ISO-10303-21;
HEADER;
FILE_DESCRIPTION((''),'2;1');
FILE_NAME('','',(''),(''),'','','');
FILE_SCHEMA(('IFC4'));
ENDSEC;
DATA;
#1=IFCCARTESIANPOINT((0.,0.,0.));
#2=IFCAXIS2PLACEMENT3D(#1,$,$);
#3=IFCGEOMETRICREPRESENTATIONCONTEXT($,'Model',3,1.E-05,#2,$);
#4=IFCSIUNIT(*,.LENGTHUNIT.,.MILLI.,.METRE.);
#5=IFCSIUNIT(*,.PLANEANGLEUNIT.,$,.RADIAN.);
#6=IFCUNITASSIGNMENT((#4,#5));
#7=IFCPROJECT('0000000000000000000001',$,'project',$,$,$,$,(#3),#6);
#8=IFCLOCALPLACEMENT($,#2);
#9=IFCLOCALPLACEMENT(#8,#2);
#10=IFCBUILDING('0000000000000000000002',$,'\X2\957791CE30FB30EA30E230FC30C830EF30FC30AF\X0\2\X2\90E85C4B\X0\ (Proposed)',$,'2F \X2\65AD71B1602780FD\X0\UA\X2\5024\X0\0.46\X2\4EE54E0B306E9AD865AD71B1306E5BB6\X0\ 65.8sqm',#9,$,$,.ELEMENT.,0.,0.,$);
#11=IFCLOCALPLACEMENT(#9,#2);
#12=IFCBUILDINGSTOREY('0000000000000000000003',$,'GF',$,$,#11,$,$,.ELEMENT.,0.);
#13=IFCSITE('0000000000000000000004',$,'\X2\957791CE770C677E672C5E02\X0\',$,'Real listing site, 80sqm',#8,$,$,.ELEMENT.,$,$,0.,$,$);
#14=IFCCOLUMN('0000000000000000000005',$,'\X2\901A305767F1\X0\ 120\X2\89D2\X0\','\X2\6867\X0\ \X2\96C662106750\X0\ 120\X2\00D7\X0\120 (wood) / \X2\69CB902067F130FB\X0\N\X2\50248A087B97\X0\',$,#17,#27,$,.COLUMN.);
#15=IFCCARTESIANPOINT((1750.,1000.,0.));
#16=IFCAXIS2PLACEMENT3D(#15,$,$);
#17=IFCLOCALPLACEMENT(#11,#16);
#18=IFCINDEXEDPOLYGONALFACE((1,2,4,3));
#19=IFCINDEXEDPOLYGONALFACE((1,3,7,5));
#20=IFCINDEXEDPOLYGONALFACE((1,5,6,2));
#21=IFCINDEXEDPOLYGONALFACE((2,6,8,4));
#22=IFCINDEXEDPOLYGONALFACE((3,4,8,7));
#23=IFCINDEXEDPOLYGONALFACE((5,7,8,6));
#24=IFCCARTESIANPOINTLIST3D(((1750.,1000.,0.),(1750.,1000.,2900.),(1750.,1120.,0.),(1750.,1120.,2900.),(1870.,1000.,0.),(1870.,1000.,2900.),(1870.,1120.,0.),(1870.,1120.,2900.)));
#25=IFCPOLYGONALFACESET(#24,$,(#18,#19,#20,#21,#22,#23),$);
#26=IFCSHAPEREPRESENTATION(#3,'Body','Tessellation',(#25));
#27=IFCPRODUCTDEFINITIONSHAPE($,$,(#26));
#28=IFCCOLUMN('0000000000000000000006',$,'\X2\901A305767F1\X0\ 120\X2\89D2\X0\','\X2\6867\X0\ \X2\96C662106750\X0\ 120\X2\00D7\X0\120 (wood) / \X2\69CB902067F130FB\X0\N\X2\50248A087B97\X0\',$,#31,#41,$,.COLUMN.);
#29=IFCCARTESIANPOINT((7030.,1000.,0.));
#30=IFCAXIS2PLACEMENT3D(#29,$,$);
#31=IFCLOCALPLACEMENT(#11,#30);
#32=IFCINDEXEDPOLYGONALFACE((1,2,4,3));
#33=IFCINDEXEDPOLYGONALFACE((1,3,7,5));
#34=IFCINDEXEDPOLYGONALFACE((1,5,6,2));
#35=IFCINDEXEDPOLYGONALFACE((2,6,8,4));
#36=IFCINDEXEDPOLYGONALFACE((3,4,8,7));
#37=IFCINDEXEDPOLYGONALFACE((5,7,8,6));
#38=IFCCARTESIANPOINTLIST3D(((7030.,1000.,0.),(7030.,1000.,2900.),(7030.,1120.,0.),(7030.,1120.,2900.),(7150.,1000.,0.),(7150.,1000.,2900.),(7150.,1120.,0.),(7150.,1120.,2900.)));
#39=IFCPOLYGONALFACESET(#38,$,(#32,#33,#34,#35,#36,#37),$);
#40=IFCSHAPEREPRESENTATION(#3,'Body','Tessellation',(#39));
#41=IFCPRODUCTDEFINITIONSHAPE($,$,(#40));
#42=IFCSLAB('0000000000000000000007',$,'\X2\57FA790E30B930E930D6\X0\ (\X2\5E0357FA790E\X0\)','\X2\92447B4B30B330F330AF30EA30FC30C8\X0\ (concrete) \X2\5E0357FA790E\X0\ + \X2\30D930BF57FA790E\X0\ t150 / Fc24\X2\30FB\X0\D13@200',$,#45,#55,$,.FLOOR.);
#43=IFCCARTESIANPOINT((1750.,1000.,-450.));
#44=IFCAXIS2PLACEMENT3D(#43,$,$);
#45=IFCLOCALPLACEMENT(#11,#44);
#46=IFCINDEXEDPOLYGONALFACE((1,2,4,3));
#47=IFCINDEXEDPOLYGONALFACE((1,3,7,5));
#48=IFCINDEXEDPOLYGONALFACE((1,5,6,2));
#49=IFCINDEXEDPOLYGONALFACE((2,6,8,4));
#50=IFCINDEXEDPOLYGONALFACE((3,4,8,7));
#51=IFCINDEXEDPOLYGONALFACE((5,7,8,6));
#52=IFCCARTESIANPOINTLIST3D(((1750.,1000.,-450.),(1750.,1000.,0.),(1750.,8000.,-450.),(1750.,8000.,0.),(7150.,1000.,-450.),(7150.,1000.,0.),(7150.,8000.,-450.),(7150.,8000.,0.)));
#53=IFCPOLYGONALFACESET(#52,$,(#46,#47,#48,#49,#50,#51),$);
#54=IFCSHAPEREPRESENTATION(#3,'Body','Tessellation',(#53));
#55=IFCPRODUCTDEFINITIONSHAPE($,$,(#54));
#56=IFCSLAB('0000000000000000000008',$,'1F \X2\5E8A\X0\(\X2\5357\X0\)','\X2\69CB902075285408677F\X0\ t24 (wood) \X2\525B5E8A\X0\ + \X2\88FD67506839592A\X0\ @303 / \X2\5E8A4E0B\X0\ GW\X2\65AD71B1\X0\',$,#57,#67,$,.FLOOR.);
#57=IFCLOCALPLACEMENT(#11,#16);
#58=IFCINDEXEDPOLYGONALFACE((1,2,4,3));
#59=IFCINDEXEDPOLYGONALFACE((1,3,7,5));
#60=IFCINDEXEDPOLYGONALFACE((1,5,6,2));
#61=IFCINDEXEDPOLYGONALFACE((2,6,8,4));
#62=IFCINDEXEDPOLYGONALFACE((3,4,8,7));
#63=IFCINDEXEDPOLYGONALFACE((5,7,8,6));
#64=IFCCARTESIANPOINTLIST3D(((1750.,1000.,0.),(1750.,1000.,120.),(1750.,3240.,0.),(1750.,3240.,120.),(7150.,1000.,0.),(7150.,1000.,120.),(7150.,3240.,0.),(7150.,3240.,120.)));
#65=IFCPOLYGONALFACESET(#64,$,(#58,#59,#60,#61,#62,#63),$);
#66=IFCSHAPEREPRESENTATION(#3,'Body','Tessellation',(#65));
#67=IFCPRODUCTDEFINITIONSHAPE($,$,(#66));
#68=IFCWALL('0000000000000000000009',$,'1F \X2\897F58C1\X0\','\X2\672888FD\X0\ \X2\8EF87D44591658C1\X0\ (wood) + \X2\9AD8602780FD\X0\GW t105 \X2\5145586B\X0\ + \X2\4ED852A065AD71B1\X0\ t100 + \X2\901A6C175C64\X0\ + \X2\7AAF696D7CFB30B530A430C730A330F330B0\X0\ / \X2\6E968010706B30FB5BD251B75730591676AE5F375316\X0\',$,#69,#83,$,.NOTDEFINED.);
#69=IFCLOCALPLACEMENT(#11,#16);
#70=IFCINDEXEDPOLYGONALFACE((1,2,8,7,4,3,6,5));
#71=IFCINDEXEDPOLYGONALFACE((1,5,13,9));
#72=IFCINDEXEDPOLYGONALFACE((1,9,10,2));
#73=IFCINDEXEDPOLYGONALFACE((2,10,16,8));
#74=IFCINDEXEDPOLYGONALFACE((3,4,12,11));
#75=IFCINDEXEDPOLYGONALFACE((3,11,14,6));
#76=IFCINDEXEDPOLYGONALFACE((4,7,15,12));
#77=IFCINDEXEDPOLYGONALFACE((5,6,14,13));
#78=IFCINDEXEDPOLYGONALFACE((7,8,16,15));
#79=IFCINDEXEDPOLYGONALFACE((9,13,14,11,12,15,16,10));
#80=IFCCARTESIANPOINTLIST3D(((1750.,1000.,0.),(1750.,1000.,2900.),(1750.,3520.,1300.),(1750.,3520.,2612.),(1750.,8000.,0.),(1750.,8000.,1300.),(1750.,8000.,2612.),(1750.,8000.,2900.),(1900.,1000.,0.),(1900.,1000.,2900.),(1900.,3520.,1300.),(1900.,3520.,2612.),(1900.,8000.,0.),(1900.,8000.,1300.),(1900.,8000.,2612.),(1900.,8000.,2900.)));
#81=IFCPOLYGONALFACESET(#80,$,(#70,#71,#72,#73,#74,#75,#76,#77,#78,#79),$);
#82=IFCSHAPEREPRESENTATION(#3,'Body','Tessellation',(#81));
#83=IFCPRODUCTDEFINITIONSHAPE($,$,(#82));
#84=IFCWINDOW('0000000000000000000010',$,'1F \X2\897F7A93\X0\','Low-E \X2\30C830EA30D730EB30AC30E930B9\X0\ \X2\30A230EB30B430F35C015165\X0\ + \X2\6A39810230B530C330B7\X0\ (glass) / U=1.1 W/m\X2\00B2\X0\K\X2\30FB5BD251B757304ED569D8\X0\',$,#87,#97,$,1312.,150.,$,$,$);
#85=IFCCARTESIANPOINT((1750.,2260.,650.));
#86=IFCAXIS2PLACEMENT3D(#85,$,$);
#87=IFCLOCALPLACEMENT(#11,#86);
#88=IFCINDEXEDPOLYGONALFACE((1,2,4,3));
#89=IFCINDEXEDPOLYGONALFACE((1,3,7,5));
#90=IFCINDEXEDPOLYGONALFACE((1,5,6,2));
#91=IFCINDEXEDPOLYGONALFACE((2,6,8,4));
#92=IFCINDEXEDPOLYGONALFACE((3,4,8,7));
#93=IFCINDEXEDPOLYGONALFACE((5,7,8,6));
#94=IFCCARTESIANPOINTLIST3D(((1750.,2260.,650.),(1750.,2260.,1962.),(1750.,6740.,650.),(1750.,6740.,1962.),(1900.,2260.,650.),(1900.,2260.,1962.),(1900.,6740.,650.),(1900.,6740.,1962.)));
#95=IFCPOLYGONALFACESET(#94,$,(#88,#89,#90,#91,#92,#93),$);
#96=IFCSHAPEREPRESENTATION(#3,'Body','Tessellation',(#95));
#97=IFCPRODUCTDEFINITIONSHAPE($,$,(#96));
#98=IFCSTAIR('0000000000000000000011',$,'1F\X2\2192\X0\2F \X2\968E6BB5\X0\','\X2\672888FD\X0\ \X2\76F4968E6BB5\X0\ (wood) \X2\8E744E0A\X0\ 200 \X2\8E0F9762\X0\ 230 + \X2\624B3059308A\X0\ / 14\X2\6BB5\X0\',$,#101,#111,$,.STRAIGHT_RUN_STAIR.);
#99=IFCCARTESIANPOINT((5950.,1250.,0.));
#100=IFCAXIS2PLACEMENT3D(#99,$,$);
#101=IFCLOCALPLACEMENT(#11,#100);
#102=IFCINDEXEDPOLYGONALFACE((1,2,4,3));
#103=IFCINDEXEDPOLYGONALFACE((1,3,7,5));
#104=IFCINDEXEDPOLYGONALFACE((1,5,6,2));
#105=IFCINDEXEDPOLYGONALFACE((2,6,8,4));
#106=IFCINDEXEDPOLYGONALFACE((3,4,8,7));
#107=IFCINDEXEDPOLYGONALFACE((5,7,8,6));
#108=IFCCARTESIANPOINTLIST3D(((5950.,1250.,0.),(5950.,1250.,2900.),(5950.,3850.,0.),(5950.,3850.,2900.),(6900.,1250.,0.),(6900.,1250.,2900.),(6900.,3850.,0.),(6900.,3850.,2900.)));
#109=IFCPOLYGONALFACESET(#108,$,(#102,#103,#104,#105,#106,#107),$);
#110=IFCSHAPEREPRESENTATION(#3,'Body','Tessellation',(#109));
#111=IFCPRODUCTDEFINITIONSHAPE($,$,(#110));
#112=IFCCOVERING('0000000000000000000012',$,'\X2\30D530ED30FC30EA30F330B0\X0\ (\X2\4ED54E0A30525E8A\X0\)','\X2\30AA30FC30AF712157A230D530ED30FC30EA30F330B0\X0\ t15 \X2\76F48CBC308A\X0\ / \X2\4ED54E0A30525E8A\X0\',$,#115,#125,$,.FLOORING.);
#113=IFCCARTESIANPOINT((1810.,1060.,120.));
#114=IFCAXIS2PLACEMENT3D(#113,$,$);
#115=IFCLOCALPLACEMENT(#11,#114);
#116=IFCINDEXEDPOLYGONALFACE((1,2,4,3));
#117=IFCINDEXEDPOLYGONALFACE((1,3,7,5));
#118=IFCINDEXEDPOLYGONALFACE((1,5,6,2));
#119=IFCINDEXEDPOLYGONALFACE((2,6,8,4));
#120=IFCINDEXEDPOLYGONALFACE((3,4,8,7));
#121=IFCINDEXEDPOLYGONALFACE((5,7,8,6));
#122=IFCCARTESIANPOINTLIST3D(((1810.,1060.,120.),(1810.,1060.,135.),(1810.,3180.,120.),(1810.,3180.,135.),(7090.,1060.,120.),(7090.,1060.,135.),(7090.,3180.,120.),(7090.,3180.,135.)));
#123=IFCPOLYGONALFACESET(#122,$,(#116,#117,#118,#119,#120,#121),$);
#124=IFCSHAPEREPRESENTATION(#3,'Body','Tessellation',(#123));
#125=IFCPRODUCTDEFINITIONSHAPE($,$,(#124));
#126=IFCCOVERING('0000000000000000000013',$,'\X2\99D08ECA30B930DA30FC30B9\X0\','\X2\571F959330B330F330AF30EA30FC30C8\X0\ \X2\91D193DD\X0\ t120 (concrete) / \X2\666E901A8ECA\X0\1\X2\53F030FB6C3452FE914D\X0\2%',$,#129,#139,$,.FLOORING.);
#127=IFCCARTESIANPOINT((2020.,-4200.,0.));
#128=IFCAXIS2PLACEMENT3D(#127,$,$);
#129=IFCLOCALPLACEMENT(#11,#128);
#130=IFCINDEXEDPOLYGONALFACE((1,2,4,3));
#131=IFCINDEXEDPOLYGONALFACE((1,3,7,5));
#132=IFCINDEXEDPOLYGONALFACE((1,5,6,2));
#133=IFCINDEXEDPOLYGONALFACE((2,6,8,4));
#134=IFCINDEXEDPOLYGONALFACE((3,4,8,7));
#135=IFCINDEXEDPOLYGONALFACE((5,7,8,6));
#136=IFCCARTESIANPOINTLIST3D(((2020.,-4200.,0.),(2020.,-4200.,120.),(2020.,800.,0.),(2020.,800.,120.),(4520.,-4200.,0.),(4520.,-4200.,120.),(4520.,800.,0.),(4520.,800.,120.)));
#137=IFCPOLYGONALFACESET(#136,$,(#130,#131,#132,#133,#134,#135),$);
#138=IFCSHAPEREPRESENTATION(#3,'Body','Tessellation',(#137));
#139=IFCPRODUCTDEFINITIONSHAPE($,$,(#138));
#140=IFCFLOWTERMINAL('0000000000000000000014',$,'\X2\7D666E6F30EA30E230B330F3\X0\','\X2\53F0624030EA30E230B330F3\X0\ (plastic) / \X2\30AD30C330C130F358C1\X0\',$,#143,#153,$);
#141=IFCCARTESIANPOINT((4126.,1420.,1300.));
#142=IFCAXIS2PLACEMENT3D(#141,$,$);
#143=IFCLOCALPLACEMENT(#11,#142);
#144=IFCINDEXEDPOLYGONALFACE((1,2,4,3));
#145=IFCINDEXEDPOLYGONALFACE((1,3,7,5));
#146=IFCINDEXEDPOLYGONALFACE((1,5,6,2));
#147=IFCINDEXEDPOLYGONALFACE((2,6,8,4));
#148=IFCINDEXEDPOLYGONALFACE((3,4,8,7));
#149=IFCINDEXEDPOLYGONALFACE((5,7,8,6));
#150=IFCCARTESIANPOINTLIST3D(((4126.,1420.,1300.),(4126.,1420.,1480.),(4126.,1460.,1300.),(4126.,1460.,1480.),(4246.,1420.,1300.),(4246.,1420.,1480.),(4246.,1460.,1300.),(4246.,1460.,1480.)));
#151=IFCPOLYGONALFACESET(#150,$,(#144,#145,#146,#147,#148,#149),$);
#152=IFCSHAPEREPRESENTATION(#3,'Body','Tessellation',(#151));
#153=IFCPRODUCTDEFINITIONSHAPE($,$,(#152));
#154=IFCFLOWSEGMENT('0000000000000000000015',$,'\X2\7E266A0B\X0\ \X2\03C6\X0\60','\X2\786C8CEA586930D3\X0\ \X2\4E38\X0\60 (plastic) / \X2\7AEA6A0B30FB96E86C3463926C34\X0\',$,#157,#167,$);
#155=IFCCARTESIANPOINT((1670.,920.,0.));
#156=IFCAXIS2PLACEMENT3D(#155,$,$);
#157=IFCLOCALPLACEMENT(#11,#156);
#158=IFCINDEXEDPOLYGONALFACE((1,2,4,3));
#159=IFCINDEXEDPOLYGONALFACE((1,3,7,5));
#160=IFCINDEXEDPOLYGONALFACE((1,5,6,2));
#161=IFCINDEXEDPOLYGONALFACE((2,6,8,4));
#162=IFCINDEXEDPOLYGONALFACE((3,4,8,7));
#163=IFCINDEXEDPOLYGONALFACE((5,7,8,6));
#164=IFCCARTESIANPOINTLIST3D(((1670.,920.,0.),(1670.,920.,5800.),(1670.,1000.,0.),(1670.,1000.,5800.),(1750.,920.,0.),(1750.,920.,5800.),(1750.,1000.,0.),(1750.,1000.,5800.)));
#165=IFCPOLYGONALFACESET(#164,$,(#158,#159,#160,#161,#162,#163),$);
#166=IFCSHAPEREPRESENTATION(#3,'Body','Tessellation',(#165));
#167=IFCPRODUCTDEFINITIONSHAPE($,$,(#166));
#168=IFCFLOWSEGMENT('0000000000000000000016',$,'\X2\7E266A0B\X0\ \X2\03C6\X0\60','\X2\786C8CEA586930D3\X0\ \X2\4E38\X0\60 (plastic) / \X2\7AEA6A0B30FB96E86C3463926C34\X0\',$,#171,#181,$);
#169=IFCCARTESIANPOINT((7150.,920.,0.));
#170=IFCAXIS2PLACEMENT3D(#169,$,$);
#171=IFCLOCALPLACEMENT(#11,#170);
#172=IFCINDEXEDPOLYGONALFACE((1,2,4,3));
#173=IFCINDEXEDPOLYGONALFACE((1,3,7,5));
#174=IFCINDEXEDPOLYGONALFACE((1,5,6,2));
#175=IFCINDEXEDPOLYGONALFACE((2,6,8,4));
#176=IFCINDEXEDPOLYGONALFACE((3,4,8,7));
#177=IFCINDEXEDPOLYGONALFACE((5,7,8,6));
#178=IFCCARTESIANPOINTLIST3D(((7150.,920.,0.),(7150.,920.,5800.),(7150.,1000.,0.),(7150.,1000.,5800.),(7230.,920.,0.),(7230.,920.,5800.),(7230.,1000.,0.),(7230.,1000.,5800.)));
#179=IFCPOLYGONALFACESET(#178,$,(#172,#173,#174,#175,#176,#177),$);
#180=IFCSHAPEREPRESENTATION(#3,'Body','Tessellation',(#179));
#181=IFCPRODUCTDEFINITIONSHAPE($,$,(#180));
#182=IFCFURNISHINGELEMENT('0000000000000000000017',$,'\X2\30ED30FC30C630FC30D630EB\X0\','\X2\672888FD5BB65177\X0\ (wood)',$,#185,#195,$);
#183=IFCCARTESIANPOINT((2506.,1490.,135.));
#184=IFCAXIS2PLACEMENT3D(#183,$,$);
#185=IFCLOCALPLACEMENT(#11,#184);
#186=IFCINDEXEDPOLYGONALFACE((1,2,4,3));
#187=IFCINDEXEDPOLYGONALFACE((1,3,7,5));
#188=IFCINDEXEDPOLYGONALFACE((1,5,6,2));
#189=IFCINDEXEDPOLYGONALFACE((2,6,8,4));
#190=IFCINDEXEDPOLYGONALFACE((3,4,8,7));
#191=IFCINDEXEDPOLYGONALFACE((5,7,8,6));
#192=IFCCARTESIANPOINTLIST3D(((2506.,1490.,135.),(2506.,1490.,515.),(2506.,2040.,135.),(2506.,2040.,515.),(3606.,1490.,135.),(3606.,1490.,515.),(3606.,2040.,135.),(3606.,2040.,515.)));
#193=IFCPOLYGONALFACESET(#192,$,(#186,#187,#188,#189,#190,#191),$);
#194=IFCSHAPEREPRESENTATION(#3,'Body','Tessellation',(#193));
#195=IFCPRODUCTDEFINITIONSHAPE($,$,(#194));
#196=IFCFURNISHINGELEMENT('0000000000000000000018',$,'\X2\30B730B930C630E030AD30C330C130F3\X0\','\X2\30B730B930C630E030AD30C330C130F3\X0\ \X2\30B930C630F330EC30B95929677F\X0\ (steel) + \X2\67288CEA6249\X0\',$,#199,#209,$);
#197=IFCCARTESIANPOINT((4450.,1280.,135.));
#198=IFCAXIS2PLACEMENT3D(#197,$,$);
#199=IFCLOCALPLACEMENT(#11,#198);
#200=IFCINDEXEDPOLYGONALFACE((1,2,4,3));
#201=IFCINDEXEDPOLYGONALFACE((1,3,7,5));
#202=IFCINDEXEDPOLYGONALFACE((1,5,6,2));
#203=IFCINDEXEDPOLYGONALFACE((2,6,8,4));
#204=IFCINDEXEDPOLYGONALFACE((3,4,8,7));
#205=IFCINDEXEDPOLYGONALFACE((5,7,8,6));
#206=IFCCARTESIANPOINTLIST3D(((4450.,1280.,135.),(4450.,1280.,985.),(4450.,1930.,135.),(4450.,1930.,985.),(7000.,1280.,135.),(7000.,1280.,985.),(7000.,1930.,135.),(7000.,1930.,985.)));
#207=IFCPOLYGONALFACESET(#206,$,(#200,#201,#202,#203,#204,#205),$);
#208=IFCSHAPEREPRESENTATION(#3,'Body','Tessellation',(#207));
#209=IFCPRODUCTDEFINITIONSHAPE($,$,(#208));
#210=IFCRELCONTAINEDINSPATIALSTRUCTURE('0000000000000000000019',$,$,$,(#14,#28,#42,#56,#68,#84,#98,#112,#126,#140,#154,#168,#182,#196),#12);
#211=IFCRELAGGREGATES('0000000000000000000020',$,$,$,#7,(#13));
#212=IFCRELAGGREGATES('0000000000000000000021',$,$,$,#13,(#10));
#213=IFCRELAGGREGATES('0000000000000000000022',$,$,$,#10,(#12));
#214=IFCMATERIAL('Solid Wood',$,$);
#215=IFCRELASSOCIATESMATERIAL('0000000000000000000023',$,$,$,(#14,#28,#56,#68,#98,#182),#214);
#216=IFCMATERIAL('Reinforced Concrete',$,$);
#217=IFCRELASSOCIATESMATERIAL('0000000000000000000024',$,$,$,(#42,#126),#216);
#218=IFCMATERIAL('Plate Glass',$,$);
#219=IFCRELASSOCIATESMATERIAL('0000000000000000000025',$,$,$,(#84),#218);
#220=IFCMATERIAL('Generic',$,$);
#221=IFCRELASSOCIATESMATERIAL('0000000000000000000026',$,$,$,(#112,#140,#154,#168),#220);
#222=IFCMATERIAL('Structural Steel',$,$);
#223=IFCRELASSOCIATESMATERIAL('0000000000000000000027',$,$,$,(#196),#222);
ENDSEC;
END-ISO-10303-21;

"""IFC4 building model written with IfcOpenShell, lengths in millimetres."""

from ifc_helpers import new_model, si_unit, frame, frame_2d, origin, place, context, project, spatial, rectangle, extrude, material, element, fill, save


model = new_model("IFC4")

# Units and contexts
model_context = context("Model", 3, precision=1e-05, world=origin())
ifc_project = project(units=[si_unit("LENGTHUNIT", "METRE", prefix="MILLI"), si_unit("PLANEANGLEUNIT", "RADIAN")], contexts=[model_context])

# Site, building, storey
site_placement = place(None, origin())
site = spatial("IfcSite", under=ifc_project, at=site_placement, Name="長野県松本市", ObjectType="Real listing site, 80sqm", CompositionType="ELEMENT", RefElevation=0.0)
building_placement = place(site_placement, origin())
building = spatial("IfcBuilding", under=site, at=building_placement, Name="長野・リモートワーク2部屋 (Proposed)", ObjectType="2F 断熱性能UA値0.46以下の高断熱の家 65.8sqm", CompositionType="ELEMENT", ElevationOfRefHeight=0.0, ElevationOfTerrain=0.0)
storey_placement = place(building_placement, origin())
storey = spatial("IfcBuildingStorey", under=building, at=storey_placement, Name="GF", CompositionType="ELEMENT", Elevation=0.0)

# Columns
ifc_material_1 = material(Name="Solid Wood")
column_1_placement = place(storey_placement, frame((1750.0, 1000.0, 0.0)))
element("IfcColumn", 1, at=column_1_placement, inside=storey, material=ifc_material_1, Name="通し柱 120角", Description="桧 集成材 120×120 (wood) / 構造柱・N値計算", PredefinedType="COLUMN", context=model_context, shape_type="SweptSolid", body=[
    extrude(rectangle(XDim=120.0, YDim=120.0, at=frame_2d((60.0, 60.0))), frame((1750.0, 1000.0, 0.0)), (0.0, 0.0, 1.0), 2900.0),
])
column_2_placement = place(storey_placement, frame((7030.0, 1000.0, 0.0)))
element("IfcColumn", 2, at=column_2_placement, inside=storey, material=ifc_material_1, Name="通し柱 120角", Description="桧 集成材 120×120 (wood) / 構造柱・N値計算", PredefinedType="COLUMN", context=model_context, shape_type="SweptSolid", body=[
    extrude(rectangle(XDim=120.0, YDim=120.0, at=frame_2d((60.0, 60.0))), frame((7030.0, 1000.0, 0.0)), (0.0, 0.0, 1.0), 2900.0),
])

# Slabs
ifc_material_2 = material(Name="Reinforced Concrete")
slab_1_placement = place(storey_placement, frame((1750.0, 1000.0, -450.0)))
element("IfcSlab", 3, at=slab_1_placement, inside=storey, material=ifc_material_2, Name="基礎スラブ (布基礎)", Description="鉄筋コンクリート (concrete) 布基礎 + ベタ基礎 t150 / Fc24・D13@200", PredefinedType="FLOOR", context=model_context, shape_type="SweptSolid", body=[
    extrude(rectangle(XDim=5400.0, YDim=7000.0, at=frame_2d((2700.0, 3500.0))), frame((1750.0, 1000.0, -450.0)), (0.0, 0.0, 1.0), 450.0),
])
slab_2_placement = place(storey_placement, frame((1750.0, 1000.0, 0.0)))
element("IfcSlab", 4, at=slab_2_placement, inside=storey, material=ifc_material_1, Name="1F 床(南)", Description="構造用合板 t24 (wood) 剛床 + 製材根太 @303 / 床下 GW断熱", PredefinedType="FLOOR", context=model_context, shape_type="SweptSolid", body=[
    extrude(rectangle(XDim=5400.0, YDim=2240.0, at=frame_2d((2700.0, 1120.0))), frame((1750.0, 1000.0, 0.0)), (0.0, 0.0, 1.0), 120.0),
])

# Shared definitions
ifc_material_3 = material(Name="Plate Glass")

# Wall, opening, window
wall_1_placement = place(storey_placement, frame((1750.0, 1000.0, 0.0)))
wall_1 = element("IfcWall", 5, at=wall_1_placement, inside=storey, material=ifc_material_1, Name="1F 西壁", Description="木製 軸組外壁 (wood) + 高性能GW t105 充填 + 付加断熱 t100 + 通気層 + 窯業系サイディング / 準耐火・寒冷地外皮強化", PredefinedType="NOTDEFINED", context=model_context, shape_type="SweptSolid", body=[
    extrude(rectangle(XDim=150.0, YDim=7000.0, at=frame_2d((75.0, 3500.0))), frame((1750.0, 1000.0, 0.0)), (0.0, 0.0, 1.0), 2900.0),
])
opening_1_placement = place(storey_placement, frame((1750.0, 2260.0, 650.0)))
opening_1 = element("IfcOpeningElement", 6, at=opening_1_placement, cuts=wall_1, PredefinedType="NOTDEFINED", context=model_context, shape_type="SweptSolid", body=[
    extrude(rectangle(XDim=150.0, YDim=4480.0, at=frame_2d((75.0, 2240.0))), frame((1750.0, 2260.0, 650.0)), (0.0, 0.0, 1.0), 1312.0),
])
window_1_placement = place(storey_placement, frame((1750.0, 2260.0, 650.0)))
window_1 = element("IfcWindow", 7, at=window_1_placement, inside=storey, material=ifc_material_3, Name="1F 西窓", Description="Low-E トリプルガラス アルゴン封入 + 樹脂サッシ (glass) / U=1.1 W/m²K・寒冷地仕様", OverallHeight=1312.0, OverallWidth=150.0, context=model_context, shape_type="SweptSolid", body=[
    extrude(rectangle(XDim=150.0, YDim=4480.0, at=frame_2d((75.0, 2240.0))), frame((1750.0, 2260.0, 650.0)), (0.0, 0.0, 1.0), 1312.0),
])
fill(opening_1, window_1)

# Stair
stair_placement = place(storey_placement, frame((5950.0, 1250.0, 0.0)))
element("IfcStair", 8, at=stair_placement, inside=storey, material=ifc_material_1, Name="1F→2F 階段", Description="木製 直階段 (wood) 蹴上 200 踏面 230 + 手すり / 14段", PredefinedType="STRAIGHT_RUN_STAIR", context=model_context, shape_type="SweptSolid", body=[
    extrude(rectangle(XDim=950.0, YDim=2600.0, at=frame_2d((475.0, 1300.0))), frame((5950.0, 1250.0, 0.0)), (0.0, 0.0, 1.0), 2900.0),
])

# Coverings
ifc_material_4 = material(Name="Generic")
covering_1_placement = place(storey_placement, frame((1810.0, 1060.0, 120.0)))
element("IfcCovering", 9, at=covering_1_placement, inside=storey, material=ifc_material_4, Name="フローリング (仕上げ床)", Description="オーク無垢フローリング t15 直貼り / 仕上げ床", PredefinedType="FLOORING", context=model_context, shape_type="SweptSolid", body=[
    extrude(rectangle(XDim=5280.0, YDim=2120.0, at=frame_2d((2640.0, 1060.0))), frame((1810.0, 1060.0, 120.0)), (0.0, 0.0, 1.0), 15.0),
])
covering_2_placement = place(storey_placement, frame((2020.0, -4200.0, 0.0)))
element("IfcCovering", 10, at=covering_2_placement, inside=storey, material=ifc_material_2, Name="駐車スペース", Description="土間コンクリート 金鏝 t120 (concrete) / 普通車1台・水勾配2%", PredefinedType="FLOORING", context=model_context, shape_type="SweptSolid", body=[
    extrude(rectangle(XDim=2500.0, YDim=5000.0, at=frame_2d((1250.0, 2500.0))), frame((2020.0, -4200.0, 0.0)), (0.0, 0.0, 1.0), 120.0),
])

# Flow terminal
flow_terminal_placement = place(storey_placement, frame((4126.0, 1420.0, 1300.0)))
element("IfcFlowTerminal", 11, at=flow_terminal_placement, inside=storey, material=ifc_material_4, Name="給湯リモコン", Description="台所リモコン (plastic) / キッチン壁", context=model_context, shape_type="SweptSolid", body=[
    extrude(rectangle(XDim=120.0, YDim=40.0, at=frame_2d((60.0, 20.0))), frame((4126.0, 1420.0, 1300.0)), (0.0, 0.0, 1.0), 180.0),
])

# Flow segments
flow_segment_1_placement = place(storey_placement, frame((1670.0, 920.0, 0.0)))
element("IfcFlowSegment", 12, at=flow_segment_1_placement, inside=storey, material=ifc_material_4, Name="縦樋 φ60", Description="硬質塩ビ 丸60 (plastic) / 竪樋・雨水排水", context=model_context, shape_type="SweptSolid", body=[
    extrude(rectangle(XDim=80.0, YDim=80.0, at=frame_2d((40.0, 40.0))), frame((1670.0, 920.0, 0.0)), (0.0, 0.0, 1.0), 5800.0),
])
flow_segment_2_placement = place(storey_placement, frame((7150.0, 920.0, 0.0)))
element("IfcFlowSegment", 13, at=flow_segment_2_placement, inside=storey, material=ifc_material_4, Name="縦樋 φ60", Description="硬質塩ビ 丸60 (plastic) / 竪樋・雨水排水", context=model_context, shape_type="SweptSolid", body=[
    extrude(rectangle(XDim=80.0, YDim=80.0, at=frame_2d((40.0, 40.0))), frame((7150.0, 920.0, 0.0)), (0.0, 0.0, 1.0), 5800.0),
])

# Furnishing elements
furnishing_1_placement = place(storey_placement, frame((2506.0, 1490.0, 135.0)))
element("IfcFurnishingElement", 14, at=furnishing_1_placement, inside=storey, material=ifc_material_1, Name="ローテーブル", Description="木製家具 (wood)", context=model_context, shape_type="SweptSolid", body=[
    extrude(rectangle(XDim=1100.0, YDim=550.0, at=frame_2d((550.0, 275.0))), frame((2506.0, 1490.0, 135.0)), (0.0, 0.0, 1.0), 380.0),
])
ifc_material_5 = material(Name="Structural Steel")
furnishing_2_placement = place(storey_placement, frame((4450.0, 1280.0, 135.0)))
element("IfcFurnishingElement", 15, at=furnishing_2_placement, inside=storey, material=ifc_material_5, Name="システムキッチン", Description="システムキッチン ステンレス天板 (steel) + 木質扉", context=model_context, shape_type="SweptSolid", body=[
    extrude(rectangle(XDim=2550.0, YDim=650.0, at=frame_2d((1275.0, 325.0))), frame((4450.0, 1280.0, 135.0)), (0.0, 0.0, 1.0), 850.0),
])

save(model, "model.ifc")
